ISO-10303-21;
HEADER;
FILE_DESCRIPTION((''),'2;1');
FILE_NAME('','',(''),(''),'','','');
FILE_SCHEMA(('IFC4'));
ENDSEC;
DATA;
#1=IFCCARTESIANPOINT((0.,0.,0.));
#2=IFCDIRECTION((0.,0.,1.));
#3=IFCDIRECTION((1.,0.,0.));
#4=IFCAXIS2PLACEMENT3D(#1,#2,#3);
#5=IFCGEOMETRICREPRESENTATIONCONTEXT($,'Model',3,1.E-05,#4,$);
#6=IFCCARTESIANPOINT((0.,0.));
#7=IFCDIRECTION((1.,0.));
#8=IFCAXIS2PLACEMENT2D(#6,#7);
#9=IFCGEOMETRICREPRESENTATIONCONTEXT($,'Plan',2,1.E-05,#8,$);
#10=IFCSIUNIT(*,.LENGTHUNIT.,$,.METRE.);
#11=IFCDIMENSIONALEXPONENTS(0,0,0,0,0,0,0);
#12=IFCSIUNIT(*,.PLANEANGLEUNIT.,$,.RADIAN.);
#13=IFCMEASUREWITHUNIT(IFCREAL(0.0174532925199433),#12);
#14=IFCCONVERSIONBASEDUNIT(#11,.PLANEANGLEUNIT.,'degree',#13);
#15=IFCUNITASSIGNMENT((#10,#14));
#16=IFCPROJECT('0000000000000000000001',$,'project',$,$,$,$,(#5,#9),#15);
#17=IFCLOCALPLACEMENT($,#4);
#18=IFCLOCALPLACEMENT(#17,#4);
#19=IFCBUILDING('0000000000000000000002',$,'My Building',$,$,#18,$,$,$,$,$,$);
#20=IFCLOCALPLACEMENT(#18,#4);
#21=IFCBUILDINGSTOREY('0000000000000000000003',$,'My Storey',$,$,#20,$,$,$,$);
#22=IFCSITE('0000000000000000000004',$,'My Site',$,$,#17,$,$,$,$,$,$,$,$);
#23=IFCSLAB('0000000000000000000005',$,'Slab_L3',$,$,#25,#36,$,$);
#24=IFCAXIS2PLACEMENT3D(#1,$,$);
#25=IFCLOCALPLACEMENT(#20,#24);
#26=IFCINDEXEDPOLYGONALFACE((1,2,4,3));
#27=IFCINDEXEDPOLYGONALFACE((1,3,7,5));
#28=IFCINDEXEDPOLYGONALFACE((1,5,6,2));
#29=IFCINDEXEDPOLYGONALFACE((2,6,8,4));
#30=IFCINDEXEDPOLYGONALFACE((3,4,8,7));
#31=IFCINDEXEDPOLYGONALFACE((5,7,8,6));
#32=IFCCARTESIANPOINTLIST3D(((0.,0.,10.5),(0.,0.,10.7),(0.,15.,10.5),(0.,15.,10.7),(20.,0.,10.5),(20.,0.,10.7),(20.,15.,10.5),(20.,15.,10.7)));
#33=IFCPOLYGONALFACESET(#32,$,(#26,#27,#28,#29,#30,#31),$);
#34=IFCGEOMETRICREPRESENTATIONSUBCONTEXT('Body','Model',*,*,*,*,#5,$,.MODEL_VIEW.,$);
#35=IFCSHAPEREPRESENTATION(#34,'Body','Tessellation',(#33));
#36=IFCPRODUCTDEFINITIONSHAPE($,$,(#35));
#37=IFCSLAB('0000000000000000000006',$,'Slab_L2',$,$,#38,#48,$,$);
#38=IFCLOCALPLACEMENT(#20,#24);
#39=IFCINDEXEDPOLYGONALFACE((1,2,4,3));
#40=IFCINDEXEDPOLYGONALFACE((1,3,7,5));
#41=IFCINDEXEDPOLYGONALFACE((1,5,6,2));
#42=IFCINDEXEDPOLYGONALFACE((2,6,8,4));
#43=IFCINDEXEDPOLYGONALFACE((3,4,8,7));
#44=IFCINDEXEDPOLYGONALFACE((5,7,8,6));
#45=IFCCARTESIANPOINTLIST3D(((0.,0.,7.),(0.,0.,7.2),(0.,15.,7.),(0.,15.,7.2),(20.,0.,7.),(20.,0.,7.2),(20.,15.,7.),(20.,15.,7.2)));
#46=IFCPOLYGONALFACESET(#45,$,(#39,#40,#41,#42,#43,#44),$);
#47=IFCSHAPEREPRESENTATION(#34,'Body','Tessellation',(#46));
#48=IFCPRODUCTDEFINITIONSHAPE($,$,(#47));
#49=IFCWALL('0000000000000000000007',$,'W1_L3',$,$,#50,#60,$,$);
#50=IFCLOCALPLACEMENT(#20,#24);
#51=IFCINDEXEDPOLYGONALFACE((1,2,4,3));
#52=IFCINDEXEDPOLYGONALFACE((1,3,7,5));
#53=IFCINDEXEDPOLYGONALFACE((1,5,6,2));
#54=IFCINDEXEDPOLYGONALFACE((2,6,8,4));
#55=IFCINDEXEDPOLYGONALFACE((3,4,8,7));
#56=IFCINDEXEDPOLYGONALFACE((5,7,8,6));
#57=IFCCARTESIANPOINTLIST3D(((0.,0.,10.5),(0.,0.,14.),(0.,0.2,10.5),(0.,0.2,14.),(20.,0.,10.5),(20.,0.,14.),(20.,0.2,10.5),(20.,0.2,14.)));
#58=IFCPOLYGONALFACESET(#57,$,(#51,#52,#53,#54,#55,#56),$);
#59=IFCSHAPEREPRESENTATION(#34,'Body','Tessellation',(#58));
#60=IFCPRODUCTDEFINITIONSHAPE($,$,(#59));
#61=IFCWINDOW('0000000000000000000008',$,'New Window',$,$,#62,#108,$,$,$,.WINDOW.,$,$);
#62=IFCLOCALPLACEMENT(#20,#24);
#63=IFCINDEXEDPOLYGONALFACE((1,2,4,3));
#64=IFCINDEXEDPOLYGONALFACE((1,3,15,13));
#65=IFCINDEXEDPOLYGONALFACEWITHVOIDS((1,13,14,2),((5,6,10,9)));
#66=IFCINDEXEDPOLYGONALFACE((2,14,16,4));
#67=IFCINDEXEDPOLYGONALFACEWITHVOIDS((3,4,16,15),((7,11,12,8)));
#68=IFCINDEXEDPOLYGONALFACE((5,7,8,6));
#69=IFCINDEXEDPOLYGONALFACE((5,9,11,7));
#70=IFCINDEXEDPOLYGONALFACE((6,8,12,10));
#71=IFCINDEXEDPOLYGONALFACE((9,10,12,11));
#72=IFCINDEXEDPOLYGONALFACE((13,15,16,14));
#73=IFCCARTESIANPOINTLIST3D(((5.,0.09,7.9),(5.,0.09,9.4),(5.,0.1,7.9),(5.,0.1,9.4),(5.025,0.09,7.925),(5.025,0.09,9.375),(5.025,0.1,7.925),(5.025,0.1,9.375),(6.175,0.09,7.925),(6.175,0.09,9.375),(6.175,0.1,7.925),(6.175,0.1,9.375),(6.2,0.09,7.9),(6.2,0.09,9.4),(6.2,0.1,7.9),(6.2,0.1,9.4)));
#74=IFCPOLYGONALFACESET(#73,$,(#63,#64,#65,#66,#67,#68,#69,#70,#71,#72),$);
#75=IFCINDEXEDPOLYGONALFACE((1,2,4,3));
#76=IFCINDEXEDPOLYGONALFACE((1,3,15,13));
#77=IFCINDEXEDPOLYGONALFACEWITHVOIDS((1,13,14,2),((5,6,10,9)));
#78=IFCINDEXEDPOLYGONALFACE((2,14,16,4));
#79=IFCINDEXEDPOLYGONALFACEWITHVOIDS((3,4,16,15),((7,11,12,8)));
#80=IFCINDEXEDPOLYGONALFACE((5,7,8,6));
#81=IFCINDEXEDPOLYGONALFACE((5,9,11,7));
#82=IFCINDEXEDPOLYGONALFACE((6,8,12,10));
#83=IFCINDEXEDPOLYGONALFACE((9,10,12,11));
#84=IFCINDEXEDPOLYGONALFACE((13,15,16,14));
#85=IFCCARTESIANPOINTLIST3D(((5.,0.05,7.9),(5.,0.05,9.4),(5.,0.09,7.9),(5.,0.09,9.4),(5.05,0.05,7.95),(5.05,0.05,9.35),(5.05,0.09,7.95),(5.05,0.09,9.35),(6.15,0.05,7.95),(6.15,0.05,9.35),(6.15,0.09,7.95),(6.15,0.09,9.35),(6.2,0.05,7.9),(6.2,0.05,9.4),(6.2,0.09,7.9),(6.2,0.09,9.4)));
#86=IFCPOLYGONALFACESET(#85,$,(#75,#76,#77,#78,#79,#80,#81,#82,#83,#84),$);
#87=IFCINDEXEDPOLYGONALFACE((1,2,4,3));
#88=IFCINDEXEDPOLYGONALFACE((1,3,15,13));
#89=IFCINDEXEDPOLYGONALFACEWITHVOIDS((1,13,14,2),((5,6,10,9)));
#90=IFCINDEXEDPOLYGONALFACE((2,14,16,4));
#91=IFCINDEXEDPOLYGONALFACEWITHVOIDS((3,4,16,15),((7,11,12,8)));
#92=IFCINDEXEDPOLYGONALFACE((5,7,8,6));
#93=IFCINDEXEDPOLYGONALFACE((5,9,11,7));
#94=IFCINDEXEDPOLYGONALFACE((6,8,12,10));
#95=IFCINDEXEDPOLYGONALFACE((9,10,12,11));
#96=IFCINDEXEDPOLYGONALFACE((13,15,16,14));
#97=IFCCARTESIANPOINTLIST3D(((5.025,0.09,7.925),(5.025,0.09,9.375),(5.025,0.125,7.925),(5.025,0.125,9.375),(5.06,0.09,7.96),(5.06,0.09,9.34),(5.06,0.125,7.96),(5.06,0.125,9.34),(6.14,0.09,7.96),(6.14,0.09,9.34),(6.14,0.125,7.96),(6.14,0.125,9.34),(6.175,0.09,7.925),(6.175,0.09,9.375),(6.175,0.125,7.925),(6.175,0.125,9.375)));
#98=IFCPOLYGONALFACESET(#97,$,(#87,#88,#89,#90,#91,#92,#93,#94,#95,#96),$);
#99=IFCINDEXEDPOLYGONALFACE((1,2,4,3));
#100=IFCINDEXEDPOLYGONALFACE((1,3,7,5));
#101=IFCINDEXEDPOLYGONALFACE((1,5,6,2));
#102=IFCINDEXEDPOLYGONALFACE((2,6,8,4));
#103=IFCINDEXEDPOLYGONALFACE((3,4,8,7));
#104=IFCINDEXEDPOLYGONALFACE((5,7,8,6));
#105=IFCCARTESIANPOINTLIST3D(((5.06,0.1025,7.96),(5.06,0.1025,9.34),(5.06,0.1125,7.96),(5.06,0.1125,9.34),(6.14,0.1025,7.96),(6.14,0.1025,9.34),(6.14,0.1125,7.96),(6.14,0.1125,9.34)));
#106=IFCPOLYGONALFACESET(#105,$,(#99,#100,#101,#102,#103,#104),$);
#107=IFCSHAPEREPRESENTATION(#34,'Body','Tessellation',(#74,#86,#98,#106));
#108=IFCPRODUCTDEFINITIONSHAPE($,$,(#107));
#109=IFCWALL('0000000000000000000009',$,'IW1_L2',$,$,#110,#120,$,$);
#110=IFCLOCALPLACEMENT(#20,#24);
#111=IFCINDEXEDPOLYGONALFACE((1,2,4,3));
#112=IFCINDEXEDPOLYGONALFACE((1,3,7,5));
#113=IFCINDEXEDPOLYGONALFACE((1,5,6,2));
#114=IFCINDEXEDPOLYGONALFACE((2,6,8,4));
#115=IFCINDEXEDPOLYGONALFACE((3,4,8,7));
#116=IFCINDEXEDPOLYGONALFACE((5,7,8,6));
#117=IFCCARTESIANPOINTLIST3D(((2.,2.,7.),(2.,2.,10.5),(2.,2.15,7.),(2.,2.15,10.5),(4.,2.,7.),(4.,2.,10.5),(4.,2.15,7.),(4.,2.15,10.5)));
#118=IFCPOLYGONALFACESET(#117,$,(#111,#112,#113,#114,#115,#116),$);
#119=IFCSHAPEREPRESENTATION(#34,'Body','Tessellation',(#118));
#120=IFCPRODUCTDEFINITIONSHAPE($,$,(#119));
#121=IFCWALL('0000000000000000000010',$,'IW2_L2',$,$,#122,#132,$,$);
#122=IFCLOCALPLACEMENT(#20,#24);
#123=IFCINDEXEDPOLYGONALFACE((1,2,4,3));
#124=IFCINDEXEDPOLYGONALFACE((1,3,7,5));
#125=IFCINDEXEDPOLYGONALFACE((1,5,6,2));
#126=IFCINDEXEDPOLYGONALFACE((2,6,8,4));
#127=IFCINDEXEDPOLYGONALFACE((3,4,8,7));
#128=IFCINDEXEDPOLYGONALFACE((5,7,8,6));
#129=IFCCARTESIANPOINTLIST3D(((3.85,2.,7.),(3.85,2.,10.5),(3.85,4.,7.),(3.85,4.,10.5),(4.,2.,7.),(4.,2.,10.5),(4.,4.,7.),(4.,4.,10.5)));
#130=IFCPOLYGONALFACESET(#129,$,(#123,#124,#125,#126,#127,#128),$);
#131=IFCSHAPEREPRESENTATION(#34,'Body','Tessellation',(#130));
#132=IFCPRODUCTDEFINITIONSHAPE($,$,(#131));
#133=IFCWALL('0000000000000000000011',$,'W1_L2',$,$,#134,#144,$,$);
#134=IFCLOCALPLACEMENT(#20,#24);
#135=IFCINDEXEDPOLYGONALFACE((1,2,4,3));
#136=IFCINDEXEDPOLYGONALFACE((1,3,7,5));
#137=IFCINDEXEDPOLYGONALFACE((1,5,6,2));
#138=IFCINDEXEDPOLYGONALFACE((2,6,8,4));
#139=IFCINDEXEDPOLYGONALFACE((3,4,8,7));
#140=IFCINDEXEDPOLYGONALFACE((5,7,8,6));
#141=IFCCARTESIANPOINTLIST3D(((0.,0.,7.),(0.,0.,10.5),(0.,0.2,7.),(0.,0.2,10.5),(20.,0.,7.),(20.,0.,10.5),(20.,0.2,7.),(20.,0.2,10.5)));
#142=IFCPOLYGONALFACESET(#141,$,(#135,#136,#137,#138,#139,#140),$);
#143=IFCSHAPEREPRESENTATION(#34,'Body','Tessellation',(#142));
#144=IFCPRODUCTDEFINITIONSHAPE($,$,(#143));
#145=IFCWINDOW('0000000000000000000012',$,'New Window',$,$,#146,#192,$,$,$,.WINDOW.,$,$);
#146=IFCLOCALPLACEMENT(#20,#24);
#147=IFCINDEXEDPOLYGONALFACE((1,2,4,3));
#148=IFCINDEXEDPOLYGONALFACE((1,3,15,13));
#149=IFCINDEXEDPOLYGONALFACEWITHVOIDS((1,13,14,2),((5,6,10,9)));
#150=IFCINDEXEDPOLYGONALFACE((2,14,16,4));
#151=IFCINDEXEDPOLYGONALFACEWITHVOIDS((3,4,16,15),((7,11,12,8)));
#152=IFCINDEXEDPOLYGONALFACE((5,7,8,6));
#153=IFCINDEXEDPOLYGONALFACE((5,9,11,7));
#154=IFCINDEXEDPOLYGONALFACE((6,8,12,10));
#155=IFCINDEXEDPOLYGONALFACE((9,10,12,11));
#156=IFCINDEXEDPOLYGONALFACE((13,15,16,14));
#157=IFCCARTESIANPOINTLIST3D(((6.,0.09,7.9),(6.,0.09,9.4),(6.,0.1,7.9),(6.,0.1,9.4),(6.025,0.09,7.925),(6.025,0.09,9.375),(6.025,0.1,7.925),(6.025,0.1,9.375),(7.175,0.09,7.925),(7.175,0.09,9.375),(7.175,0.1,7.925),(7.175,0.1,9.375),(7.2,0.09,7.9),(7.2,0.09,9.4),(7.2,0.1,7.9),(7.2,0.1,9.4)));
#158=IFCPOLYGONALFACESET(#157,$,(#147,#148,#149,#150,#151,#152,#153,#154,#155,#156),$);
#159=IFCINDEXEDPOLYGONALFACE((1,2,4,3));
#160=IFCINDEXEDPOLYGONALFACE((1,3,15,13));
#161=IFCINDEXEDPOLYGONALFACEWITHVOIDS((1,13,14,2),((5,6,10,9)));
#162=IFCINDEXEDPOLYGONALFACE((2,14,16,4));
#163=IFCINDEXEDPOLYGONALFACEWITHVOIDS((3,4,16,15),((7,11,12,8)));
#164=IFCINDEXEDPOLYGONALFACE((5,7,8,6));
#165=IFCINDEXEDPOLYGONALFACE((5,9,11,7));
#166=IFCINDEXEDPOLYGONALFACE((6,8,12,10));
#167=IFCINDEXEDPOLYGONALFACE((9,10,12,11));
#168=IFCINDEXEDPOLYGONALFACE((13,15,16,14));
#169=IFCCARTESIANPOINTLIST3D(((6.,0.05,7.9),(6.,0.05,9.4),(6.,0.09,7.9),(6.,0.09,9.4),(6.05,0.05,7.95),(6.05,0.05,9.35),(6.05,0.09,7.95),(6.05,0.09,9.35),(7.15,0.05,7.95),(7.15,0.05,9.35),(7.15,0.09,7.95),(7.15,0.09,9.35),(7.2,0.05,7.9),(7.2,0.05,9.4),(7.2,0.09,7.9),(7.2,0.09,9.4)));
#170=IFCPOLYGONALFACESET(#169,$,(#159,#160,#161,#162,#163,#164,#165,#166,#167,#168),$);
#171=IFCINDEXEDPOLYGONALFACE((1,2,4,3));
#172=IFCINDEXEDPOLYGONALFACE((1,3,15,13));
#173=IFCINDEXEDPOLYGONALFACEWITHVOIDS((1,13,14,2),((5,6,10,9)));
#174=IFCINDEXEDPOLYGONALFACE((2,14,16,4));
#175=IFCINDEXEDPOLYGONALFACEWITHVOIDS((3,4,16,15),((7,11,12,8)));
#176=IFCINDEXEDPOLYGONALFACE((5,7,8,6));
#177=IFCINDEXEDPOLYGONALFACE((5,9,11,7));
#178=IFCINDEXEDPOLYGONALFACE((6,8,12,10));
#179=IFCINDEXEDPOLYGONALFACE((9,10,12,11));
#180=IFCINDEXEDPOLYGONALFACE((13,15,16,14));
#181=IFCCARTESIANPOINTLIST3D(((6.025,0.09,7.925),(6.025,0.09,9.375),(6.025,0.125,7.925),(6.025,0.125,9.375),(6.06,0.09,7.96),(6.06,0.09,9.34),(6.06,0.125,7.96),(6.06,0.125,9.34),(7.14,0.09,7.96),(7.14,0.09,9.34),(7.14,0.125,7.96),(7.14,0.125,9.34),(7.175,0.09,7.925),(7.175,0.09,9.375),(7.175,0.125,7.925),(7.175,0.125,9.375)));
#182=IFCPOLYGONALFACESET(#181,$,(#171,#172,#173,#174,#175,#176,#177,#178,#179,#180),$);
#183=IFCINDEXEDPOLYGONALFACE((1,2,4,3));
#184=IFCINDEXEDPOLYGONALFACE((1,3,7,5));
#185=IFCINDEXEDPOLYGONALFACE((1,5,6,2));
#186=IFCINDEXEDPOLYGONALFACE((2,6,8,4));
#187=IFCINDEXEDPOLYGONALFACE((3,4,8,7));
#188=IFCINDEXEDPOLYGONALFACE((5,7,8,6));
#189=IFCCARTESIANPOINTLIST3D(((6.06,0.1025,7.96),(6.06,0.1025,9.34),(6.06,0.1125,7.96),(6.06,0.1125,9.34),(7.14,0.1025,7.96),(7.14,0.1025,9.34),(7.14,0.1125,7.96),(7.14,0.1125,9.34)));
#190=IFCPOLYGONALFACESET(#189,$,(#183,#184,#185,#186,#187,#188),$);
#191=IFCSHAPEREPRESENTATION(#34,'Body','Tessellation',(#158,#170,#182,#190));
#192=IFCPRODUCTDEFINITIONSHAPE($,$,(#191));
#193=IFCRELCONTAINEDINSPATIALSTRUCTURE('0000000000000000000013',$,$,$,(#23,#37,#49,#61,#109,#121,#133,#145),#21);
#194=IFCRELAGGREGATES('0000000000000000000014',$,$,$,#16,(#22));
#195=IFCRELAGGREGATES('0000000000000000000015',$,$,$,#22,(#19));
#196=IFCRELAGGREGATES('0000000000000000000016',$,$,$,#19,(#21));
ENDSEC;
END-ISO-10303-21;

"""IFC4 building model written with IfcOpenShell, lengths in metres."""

from ifc_helpers import new_model, entity, si_unit, converted_unit, frame, origin_with_axes, origin_2d_with_axis, place, context, subcontext, project, spatial, line, indexed_curve, outline, extrude, element, save


model = new_model("IFC4")

# Units and contexts
model_context = context("Model", 3, precision=1e-05, world=origin_with_axes())
plan_context = context("Plan", 2, precision=1e-05, world=origin_2d_with_axis())
body_context = subcontext(model_context, "Body", "Model", "MODEL_VIEW")
ifc_project = project(units=[si_unit("LENGTHUNIT", "METRE"), converted_unit("PLANEANGLEUNIT", "degree", entity("IfcReal", 0.0174532925199433), si_unit("PLANEANGLEUNIT", "RADIAN"), dimensions=[0, 0, 0, 0, 0, 0, 0])], contexts=[model_context, plan_context])

# Site, building, storey
site_placement = place(None, origin_with_axes())
site = spatial("IfcSite", under=ifc_project, at=site_placement, Name="My Site")
building_placement = place(site_placement, origin_with_axes())
building = spatial("IfcBuilding", under=site, at=building_placement, Name="My Building")
storey_placement = place(building_placement, origin_with_axes())
storey = spatial("IfcBuildingStorey", under=building, at=storey_placement, Name="My Storey")

# Slabs
for number, where, z_axis, x_axis, name in (
    (1, (0.0, 0.0, 10.5), (0.0, 0.0, 1.0), (1.0, 0.0, 0.0), "Slab_L3"),
    (2, (0.0, 0.0, 7.0), (0.0, 0.0, 1.0), (1.0, 0.0, 0.0), "Slab_L2"),
):
    element("IfcSlab", number, at=place(storey_placement, frame(where, z_axis=z_axis, x_axis=x_axis)), inside=storey, Name=name, context=body_context, shape_type="SweptSolid", body=[
        extrude(outline(indexed_curve([(0.0, 0.0), (20.0, 0.0), (20.0, 15.0), (0.0, 15.0), (0.0, 0.0)])), None, (0.0, 0.0, 1.0), 0.2),
    ])

# Wall
for number, where, z_axis, x_axis, name in (
    (3, (0.0, 0.0, 10.5), (0.0, 0.0, 1.0), (1.0, 0.0, 0.0), "W1_L3"),
):
    element("IfcWall", number, at=place(storey_placement, frame(where, z_axis=z_axis, x_axis=x_axis)), inside=storey, Name=name, context=body_context, shape_type="SweptSolid", body=[
        extrude(outline(indexed_curve([(0.0, 0.0), (0.0, 0.2), (20.0, 0.2), (20.0, 0.0), (0.0, 0.0)], self_intersect=False)), origin_with_axes(), (0.0, 0.0, 1.0), 3.5),
    ])

# Window
window_1_placement = place(storey_placement, frame((5.0, 0.0, 7.9), z_axis=(0.0, 0.0, 1.0), x_axis=(1.0, 0.0, 0.0)))
element("IfcWindow", 4, at=window_1_placement, inside=storey, Name="New Window", PredefinedType="WINDOW", context=body_context, shape_type="SweptSolid", body=[
    extrude(outline(indexed_curve([(0.0, 0.0), (1.2, 0.0), (1.2, 1.5), (0.0, 1.5)], segments=[line(1, 2, 3, 4, 1)]), holes=[indexed_curve([(0.025, 0.025), (1.175, 0.025), (1.175, 1.475), (0.025, 1.475)], segments=[line(1, 2, 3, 4, 1)])]), frame((0.0, 0.09, 0.0), z_axis=(0.0, -1.0, 0.0), x_axis=(1.0, 0.0, 0.0)), (0.0, 0.0, -1.0), 0.01),
    extrude(outline(indexed_curve([(0.0, 0.0), (1.2, 0.0), (1.2, 1.5), (0.0, 1.5)], segments=[line(1, 2, 3, 4, 1)]), holes=[indexed_curve([(0.05, 0.05), (1.15, 0.05), (1.15, 1.45), (0.05, 1.45)], segments=[line(1, 2, 3, 4, 1)])]), frame((0.0, 0.05, 0.0), z_axis=(0.0, -1.0, 0.0), x_axis=(1.0, 0.0, 0.0)), (0.0, 0.0, -1.0), 0.04),
    extrude(outline(indexed_curve([(0.0, 0.0), (1.15, 0.0), (1.15, 1.45), (0.0, 1.45)], segments=[line(1, 2, 3, 4, 1)]), holes=[indexed_curve([(0.035, 0.035), (1.115, 0.035), (1.115, 1.415), (0.035, 1.415)], segments=[line(1, 2, 3, 4, 1)])]), frame((0.025, 0.09, 0.025), z_axis=(0.0, -1.0, 0.0), x_axis=(1.0, 0.0, 0.0)), (0.0, 0.0, -1.0), 0.035),
    extrude(outline(indexed_curve([(0.035, 0.035), (1.115, 0.035), (1.115, 1.415), (0.035, 1.415)], segments=[line(1, 2, 3, 4, 1)])), frame((0.025, 0.1025, 0.025), z_axis=(0.0, -1.0, 0.0), x_axis=(1.0, 0.0, 0.0)), (0.0, 0.0, -1.0), 0.01),
])

# Walls
for number, where, z_axis, x_axis, name in (
    (5, (2.0, 2.0, 7.0), (0.0, 0.0, 1.0), (1.0, 0.0, 0.0), "IW1_L2"),
    (6, (4.0, 2.0, 7.0), (0.0, 0.0, 1.0), (0.0, 1.0, 0.0), "IW2_L2"),
):
    element("IfcWall", number, at=place(storey_placement, frame(where, z_axis=z_axis, x_axis=x_axis)), inside=storey, Name=name, context=body_context, shape_type="SweptSolid", body=[
        extrude(outline(indexed_curve([(0.0, 0.0), (0.0, 0.15), (2.0, 0.15), (2.0, 0.0), (0.0, 0.0)], self_intersect=False)), origin_with_axes(), (0.0, 0.0, 1.0), 3.5),
    ])
for number, where, z_axis, x_axis, name in (
    (7, (0.0, 0.0, 7.0), (0.0, 0.0, 1.0), (1.0, 0.0, 0.0), "W1_L2"),
):
    element("IfcWall", number, at=place(storey_placement, frame(where, z_axis=z_axis, x_axis=x_axis)), inside=storey, Name=name, context=body_context, shape_type="SweptSolid", body=[
        extrude(outline(indexed_curve([(0.0, 0.0), (0.0, 0.2), (20.0, 0.2), (20.0, 0.0), (0.0, 0.0)], self_intersect=False)), origin_with_axes(), (0.0, 0.0, 1.0), 3.5),
    ])

# Window
window_2_placement = place(storey_placement, frame((6.0, 0.0, 7.9), z_axis=(0.0, 0.0, 1.0), x_axis=(1.0, 0.0, 0.0)))
element("IfcWindow", 8, at=window_2_placement, inside=storey, Name="New Window", PredefinedType="WINDOW", context=body_context, shape_type="SweptSolid", body=[
    extrude(outline(indexed_curve([(0.0, 0.0), (1.2, 0.0), (1.2, 1.5), (0.0, 1.5)], segments=[line(1, 2, 3, 4, 1)]), holes=[indexed_curve([(0.025, 0.025), (1.175, 0.025), (1.175, 1.475), (0.025, 1.475)], segments=[line(1, 2, 3, 4, 1)])]), frame((0.0, 0.09, 0.0), z_axis=(0.0, -1.0, 0.0), x_axis=(1.0, 0.0, 0.0)), (0.0, 0.0, -1.0), 0.01),
    extrude(outline(indexed_curve([(0.0, 0.0), (1.2, 0.0), (1.2, 1.5), (0.0, 1.5)], segments=[line(1, 2, 3, 4, 1)]), holes=[indexed_curve([(0.05, 0.05), (1.15, 0.05), (1.15, 1.45), (0.05, 1.45)], segments=[line(1, 2, 3, 4, 1)])]), frame((0.0, 0.05, 0.0), z_axis=(0.0, -1.0, 0.0), x_axis=(1.0, 0.0, 0.0)), (0.0, 0.0, -1.0), 0.04),
    extrude(outline(indexed_curve([(0.0, 0.0), (1.15, 0.0), (1.15, 1.45), (0.0, 1.45)], segments=[line(1, 2, 3, 4, 1)]), holes=[indexed_curve([(0.035, 0.035), (1.115, 0.035), (1.115, 1.415), (0.035, 1.415)], segments=[line(1, 2, 3, 4, 1)])]), frame((0.025, 0.09, 0.025), z_axis=(0.0, -1.0, 0.0), x_axis=(1.0, 0.0, 0.0)), (0.0, 0.0, -1.0), 0.035),
    extrude(outline(indexed_curve([(0.035, 0.035), (1.115, 0.035), (1.115, 1.415), (0.035, 1.415)], segments=[line(1, 2, 3, 4, 1)])), frame((0.025, 0.1025, 0.025), z_axis=(0.0, -1.0, 0.0), x_axis=(1.0, 0.0, 0.0)), (0.0, 0.0, -1.0), 0.01),
])

save(model, "model.ifc")
